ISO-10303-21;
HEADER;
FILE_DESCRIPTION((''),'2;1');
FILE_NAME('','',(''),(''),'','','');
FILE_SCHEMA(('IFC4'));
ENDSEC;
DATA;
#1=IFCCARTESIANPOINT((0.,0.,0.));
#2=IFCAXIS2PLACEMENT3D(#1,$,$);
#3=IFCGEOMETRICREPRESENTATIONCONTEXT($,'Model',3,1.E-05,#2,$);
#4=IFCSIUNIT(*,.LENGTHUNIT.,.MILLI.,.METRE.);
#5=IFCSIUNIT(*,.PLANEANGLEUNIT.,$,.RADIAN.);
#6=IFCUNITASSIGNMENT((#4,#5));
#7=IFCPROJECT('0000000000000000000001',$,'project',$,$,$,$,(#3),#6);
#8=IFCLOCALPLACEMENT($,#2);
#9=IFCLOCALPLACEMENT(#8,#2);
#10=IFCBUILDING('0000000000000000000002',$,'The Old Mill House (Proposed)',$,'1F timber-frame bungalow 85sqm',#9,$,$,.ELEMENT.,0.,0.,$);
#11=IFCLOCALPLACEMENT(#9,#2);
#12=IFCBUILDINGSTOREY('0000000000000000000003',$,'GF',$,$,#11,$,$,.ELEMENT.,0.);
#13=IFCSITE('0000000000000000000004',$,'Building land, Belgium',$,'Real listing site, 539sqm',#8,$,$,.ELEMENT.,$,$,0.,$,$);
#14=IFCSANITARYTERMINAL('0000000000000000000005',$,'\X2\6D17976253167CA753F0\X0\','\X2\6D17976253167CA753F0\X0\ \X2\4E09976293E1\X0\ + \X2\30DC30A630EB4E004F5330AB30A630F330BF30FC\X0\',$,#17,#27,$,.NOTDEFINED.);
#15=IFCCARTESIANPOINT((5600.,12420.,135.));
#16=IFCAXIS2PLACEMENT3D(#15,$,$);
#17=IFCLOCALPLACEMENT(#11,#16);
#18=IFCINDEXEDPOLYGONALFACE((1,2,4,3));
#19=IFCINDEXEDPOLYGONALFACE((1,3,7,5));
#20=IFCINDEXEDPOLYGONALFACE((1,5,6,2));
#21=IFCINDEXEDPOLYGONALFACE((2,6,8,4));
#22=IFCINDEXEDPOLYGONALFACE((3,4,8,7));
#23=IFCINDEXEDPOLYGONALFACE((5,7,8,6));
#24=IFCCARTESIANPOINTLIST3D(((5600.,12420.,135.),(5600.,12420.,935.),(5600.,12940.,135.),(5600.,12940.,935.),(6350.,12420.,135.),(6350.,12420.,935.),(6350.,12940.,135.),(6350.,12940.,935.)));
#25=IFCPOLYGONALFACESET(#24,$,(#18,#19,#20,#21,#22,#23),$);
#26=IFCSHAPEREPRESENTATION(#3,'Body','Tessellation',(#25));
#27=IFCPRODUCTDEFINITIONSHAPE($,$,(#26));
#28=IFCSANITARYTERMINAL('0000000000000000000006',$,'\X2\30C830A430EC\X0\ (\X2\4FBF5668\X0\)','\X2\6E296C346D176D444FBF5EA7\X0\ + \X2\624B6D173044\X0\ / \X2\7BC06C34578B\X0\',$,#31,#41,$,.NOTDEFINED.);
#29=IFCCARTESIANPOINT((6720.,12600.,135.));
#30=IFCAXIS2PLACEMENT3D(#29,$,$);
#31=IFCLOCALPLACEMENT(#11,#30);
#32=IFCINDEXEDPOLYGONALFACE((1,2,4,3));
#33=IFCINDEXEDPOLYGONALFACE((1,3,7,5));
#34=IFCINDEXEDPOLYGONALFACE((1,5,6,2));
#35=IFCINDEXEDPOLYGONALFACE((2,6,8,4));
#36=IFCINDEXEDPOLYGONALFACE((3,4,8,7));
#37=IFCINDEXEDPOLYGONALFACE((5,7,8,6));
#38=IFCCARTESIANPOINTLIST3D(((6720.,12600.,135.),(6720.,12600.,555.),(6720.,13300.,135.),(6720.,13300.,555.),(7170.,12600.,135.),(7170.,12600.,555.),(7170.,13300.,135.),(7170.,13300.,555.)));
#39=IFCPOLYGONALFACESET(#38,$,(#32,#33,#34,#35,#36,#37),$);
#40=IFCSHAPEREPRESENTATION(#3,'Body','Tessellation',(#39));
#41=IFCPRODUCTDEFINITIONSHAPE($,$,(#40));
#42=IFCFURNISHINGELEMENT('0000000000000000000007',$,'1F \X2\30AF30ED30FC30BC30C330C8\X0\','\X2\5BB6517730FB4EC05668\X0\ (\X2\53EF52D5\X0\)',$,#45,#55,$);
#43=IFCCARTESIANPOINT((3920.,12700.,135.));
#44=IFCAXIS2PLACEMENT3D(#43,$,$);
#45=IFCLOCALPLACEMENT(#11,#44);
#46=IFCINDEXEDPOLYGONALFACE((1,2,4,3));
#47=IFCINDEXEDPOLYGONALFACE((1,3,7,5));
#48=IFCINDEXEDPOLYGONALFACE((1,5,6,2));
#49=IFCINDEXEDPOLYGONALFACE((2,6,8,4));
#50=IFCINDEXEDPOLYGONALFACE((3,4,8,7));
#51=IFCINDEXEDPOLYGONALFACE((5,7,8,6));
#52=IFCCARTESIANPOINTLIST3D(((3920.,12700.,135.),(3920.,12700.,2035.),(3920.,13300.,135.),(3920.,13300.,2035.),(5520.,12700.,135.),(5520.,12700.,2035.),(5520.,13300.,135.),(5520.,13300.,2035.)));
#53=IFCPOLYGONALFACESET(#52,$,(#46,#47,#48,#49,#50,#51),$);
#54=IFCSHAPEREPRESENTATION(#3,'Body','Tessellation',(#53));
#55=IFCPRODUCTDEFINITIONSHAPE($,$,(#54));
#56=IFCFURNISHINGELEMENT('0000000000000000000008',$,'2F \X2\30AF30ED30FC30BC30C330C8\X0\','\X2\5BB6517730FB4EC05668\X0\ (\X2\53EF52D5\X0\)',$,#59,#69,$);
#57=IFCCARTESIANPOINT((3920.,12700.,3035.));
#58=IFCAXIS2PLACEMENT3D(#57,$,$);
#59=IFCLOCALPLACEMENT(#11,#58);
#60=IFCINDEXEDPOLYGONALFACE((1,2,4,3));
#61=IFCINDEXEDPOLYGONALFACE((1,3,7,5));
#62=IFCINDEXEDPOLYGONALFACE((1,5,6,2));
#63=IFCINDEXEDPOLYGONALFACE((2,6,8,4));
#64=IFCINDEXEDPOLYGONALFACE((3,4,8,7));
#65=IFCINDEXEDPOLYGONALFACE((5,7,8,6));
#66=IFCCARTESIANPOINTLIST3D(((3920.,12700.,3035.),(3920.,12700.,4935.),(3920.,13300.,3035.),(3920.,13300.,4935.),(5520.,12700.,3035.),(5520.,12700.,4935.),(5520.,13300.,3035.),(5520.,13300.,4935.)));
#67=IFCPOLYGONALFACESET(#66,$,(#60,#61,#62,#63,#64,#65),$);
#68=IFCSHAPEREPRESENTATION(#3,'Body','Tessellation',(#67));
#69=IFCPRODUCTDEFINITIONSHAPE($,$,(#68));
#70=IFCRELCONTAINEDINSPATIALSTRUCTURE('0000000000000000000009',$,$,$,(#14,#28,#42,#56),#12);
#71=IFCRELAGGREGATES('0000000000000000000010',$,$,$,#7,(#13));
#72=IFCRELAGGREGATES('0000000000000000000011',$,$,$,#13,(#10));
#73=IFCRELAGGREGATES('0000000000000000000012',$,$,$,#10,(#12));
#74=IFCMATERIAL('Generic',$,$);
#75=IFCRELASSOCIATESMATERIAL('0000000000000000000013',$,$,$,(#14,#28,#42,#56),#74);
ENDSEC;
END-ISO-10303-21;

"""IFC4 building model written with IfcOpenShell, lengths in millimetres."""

from ifc_helpers import new_model, si_unit, frame, frame_2d, origin, place, context, project, spatial, rectangle, extrude, material, element, save


model = new_model("IFC4")

# Units and contexts
model_context = context("Model", 3, precision=1e-05, world=origin())
ifc_project = project(units=[si_unit("LENGTHUNIT", "METRE", prefix="MILLI"), si_unit("PLANEANGLEUNIT", "RADIAN")], contexts=[model_context])

# Site, building, storey
site_placement = place(None, origin())
site = spatial("IfcSite", under=ifc_project, at=site_placement, Name="Building land, Belgium", ObjectType="Real listing site, 539sqm", CompositionType="ELEMENT", RefElevation=0.0)
building_placement = place(site_placement, origin())
building = spatial("IfcBuilding", under=site, at=building_placement, Name="The Old Mill House (Proposed)", ObjectType="1F timber-frame bungalow 85sqm", CompositionType="ELEMENT", ElevationOfRefHeight=0.0, ElevationOfTerrain=0.0)
storey_placement = place(building_placement, origin())
storey = spatial("IfcBuildingStorey", under=building, at=storey_placement, Name="GF", CompositionType="ELEMENT", Elevation=0.0)

# Shared definitions
ifc_material_1 = material(Name="Generic")

# Sanitary terminals
sanitary_terminal_1_placement = place(storey_placement, frame((5600.0, 12420.0, 135.0)))
element("IfcSanitaryTerminal", 1, at=sanitary_terminal_1_placement, inside=storey, material=ifc_material_1, Name="洗面化粧台", Description="洗面化粧台 三面鏡 + ボウル一体カウンター", PredefinedType="NOTDEFINED", context=model_context, shape_type="SweptSolid", body=[
    extrude(rectangle(XDim=750.0, YDim=520.0, at=frame_2d((375.0, 260.0))), frame((5600.0, 12420.0, 135.0)), (0.0, 0.0, 1.0), 800.0),
])
sanitary_terminal_2_placement = place(storey_placement, frame((6720.0, 12600.0, 135.0)))
element("IfcSanitaryTerminal", 2, at=sanitary_terminal_2_placement, inside=storey, material=ifc_material_1, Name="トイレ (便器)", Description="温水洗浄便座 + 手洗い / 節水型", PredefinedType="NOTDEFINED", context=model_context, shape_type="SweptSolid", body=[
    extrude(rectangle(XDim=450.0, YDim=700.0, at=frame_2d((225.0, 350.0))), frame((6720.0, 12600.0, 135.0)), (0.0, 0.0, 1.0), 420.0),
])

# Furnishing elements
furnishing_1_placement = place(storey_placement, frame((3920.0, 12700.0, 135.0)))
element("IfcFurnishingElement", 3, at=furnishing_1_placement, inside=storey, material=ifc_material_1, Name="1F クローゼット", Description="家具・什器 (可動)", context=model_context, shape_type="SweptSolid", body=[
    extrude(rectangle(XDim=1600.0, YDim=600.0, at=frame_2d((800.0, 300.0))), frame((3920.0, 12700.0, 135.0)), (0.0, 0.0, 1.0), 1900.0),
])
furnishing_2_placement = place(storey_placement, frame((3920.0, 12700.0, 3035.0)))
element("IfcFurnishingElement", 4, at=furnishing_2_placement, inside=storey, material=ifc_material_1, Name="2F クローゼット", Description="家具・什器 (可動)", context=model_context, shape_type="SweptSolid", body=[
    extrude(rectangle(XDim=1600.0, YDim=600.0, at=frame_2d((800.0, 300.0))), frame((3920.0, 12700.0, 3035.0)), (0.0, 0.0, 1.0), 1900.0),
])

save(model, "model.ifc")
